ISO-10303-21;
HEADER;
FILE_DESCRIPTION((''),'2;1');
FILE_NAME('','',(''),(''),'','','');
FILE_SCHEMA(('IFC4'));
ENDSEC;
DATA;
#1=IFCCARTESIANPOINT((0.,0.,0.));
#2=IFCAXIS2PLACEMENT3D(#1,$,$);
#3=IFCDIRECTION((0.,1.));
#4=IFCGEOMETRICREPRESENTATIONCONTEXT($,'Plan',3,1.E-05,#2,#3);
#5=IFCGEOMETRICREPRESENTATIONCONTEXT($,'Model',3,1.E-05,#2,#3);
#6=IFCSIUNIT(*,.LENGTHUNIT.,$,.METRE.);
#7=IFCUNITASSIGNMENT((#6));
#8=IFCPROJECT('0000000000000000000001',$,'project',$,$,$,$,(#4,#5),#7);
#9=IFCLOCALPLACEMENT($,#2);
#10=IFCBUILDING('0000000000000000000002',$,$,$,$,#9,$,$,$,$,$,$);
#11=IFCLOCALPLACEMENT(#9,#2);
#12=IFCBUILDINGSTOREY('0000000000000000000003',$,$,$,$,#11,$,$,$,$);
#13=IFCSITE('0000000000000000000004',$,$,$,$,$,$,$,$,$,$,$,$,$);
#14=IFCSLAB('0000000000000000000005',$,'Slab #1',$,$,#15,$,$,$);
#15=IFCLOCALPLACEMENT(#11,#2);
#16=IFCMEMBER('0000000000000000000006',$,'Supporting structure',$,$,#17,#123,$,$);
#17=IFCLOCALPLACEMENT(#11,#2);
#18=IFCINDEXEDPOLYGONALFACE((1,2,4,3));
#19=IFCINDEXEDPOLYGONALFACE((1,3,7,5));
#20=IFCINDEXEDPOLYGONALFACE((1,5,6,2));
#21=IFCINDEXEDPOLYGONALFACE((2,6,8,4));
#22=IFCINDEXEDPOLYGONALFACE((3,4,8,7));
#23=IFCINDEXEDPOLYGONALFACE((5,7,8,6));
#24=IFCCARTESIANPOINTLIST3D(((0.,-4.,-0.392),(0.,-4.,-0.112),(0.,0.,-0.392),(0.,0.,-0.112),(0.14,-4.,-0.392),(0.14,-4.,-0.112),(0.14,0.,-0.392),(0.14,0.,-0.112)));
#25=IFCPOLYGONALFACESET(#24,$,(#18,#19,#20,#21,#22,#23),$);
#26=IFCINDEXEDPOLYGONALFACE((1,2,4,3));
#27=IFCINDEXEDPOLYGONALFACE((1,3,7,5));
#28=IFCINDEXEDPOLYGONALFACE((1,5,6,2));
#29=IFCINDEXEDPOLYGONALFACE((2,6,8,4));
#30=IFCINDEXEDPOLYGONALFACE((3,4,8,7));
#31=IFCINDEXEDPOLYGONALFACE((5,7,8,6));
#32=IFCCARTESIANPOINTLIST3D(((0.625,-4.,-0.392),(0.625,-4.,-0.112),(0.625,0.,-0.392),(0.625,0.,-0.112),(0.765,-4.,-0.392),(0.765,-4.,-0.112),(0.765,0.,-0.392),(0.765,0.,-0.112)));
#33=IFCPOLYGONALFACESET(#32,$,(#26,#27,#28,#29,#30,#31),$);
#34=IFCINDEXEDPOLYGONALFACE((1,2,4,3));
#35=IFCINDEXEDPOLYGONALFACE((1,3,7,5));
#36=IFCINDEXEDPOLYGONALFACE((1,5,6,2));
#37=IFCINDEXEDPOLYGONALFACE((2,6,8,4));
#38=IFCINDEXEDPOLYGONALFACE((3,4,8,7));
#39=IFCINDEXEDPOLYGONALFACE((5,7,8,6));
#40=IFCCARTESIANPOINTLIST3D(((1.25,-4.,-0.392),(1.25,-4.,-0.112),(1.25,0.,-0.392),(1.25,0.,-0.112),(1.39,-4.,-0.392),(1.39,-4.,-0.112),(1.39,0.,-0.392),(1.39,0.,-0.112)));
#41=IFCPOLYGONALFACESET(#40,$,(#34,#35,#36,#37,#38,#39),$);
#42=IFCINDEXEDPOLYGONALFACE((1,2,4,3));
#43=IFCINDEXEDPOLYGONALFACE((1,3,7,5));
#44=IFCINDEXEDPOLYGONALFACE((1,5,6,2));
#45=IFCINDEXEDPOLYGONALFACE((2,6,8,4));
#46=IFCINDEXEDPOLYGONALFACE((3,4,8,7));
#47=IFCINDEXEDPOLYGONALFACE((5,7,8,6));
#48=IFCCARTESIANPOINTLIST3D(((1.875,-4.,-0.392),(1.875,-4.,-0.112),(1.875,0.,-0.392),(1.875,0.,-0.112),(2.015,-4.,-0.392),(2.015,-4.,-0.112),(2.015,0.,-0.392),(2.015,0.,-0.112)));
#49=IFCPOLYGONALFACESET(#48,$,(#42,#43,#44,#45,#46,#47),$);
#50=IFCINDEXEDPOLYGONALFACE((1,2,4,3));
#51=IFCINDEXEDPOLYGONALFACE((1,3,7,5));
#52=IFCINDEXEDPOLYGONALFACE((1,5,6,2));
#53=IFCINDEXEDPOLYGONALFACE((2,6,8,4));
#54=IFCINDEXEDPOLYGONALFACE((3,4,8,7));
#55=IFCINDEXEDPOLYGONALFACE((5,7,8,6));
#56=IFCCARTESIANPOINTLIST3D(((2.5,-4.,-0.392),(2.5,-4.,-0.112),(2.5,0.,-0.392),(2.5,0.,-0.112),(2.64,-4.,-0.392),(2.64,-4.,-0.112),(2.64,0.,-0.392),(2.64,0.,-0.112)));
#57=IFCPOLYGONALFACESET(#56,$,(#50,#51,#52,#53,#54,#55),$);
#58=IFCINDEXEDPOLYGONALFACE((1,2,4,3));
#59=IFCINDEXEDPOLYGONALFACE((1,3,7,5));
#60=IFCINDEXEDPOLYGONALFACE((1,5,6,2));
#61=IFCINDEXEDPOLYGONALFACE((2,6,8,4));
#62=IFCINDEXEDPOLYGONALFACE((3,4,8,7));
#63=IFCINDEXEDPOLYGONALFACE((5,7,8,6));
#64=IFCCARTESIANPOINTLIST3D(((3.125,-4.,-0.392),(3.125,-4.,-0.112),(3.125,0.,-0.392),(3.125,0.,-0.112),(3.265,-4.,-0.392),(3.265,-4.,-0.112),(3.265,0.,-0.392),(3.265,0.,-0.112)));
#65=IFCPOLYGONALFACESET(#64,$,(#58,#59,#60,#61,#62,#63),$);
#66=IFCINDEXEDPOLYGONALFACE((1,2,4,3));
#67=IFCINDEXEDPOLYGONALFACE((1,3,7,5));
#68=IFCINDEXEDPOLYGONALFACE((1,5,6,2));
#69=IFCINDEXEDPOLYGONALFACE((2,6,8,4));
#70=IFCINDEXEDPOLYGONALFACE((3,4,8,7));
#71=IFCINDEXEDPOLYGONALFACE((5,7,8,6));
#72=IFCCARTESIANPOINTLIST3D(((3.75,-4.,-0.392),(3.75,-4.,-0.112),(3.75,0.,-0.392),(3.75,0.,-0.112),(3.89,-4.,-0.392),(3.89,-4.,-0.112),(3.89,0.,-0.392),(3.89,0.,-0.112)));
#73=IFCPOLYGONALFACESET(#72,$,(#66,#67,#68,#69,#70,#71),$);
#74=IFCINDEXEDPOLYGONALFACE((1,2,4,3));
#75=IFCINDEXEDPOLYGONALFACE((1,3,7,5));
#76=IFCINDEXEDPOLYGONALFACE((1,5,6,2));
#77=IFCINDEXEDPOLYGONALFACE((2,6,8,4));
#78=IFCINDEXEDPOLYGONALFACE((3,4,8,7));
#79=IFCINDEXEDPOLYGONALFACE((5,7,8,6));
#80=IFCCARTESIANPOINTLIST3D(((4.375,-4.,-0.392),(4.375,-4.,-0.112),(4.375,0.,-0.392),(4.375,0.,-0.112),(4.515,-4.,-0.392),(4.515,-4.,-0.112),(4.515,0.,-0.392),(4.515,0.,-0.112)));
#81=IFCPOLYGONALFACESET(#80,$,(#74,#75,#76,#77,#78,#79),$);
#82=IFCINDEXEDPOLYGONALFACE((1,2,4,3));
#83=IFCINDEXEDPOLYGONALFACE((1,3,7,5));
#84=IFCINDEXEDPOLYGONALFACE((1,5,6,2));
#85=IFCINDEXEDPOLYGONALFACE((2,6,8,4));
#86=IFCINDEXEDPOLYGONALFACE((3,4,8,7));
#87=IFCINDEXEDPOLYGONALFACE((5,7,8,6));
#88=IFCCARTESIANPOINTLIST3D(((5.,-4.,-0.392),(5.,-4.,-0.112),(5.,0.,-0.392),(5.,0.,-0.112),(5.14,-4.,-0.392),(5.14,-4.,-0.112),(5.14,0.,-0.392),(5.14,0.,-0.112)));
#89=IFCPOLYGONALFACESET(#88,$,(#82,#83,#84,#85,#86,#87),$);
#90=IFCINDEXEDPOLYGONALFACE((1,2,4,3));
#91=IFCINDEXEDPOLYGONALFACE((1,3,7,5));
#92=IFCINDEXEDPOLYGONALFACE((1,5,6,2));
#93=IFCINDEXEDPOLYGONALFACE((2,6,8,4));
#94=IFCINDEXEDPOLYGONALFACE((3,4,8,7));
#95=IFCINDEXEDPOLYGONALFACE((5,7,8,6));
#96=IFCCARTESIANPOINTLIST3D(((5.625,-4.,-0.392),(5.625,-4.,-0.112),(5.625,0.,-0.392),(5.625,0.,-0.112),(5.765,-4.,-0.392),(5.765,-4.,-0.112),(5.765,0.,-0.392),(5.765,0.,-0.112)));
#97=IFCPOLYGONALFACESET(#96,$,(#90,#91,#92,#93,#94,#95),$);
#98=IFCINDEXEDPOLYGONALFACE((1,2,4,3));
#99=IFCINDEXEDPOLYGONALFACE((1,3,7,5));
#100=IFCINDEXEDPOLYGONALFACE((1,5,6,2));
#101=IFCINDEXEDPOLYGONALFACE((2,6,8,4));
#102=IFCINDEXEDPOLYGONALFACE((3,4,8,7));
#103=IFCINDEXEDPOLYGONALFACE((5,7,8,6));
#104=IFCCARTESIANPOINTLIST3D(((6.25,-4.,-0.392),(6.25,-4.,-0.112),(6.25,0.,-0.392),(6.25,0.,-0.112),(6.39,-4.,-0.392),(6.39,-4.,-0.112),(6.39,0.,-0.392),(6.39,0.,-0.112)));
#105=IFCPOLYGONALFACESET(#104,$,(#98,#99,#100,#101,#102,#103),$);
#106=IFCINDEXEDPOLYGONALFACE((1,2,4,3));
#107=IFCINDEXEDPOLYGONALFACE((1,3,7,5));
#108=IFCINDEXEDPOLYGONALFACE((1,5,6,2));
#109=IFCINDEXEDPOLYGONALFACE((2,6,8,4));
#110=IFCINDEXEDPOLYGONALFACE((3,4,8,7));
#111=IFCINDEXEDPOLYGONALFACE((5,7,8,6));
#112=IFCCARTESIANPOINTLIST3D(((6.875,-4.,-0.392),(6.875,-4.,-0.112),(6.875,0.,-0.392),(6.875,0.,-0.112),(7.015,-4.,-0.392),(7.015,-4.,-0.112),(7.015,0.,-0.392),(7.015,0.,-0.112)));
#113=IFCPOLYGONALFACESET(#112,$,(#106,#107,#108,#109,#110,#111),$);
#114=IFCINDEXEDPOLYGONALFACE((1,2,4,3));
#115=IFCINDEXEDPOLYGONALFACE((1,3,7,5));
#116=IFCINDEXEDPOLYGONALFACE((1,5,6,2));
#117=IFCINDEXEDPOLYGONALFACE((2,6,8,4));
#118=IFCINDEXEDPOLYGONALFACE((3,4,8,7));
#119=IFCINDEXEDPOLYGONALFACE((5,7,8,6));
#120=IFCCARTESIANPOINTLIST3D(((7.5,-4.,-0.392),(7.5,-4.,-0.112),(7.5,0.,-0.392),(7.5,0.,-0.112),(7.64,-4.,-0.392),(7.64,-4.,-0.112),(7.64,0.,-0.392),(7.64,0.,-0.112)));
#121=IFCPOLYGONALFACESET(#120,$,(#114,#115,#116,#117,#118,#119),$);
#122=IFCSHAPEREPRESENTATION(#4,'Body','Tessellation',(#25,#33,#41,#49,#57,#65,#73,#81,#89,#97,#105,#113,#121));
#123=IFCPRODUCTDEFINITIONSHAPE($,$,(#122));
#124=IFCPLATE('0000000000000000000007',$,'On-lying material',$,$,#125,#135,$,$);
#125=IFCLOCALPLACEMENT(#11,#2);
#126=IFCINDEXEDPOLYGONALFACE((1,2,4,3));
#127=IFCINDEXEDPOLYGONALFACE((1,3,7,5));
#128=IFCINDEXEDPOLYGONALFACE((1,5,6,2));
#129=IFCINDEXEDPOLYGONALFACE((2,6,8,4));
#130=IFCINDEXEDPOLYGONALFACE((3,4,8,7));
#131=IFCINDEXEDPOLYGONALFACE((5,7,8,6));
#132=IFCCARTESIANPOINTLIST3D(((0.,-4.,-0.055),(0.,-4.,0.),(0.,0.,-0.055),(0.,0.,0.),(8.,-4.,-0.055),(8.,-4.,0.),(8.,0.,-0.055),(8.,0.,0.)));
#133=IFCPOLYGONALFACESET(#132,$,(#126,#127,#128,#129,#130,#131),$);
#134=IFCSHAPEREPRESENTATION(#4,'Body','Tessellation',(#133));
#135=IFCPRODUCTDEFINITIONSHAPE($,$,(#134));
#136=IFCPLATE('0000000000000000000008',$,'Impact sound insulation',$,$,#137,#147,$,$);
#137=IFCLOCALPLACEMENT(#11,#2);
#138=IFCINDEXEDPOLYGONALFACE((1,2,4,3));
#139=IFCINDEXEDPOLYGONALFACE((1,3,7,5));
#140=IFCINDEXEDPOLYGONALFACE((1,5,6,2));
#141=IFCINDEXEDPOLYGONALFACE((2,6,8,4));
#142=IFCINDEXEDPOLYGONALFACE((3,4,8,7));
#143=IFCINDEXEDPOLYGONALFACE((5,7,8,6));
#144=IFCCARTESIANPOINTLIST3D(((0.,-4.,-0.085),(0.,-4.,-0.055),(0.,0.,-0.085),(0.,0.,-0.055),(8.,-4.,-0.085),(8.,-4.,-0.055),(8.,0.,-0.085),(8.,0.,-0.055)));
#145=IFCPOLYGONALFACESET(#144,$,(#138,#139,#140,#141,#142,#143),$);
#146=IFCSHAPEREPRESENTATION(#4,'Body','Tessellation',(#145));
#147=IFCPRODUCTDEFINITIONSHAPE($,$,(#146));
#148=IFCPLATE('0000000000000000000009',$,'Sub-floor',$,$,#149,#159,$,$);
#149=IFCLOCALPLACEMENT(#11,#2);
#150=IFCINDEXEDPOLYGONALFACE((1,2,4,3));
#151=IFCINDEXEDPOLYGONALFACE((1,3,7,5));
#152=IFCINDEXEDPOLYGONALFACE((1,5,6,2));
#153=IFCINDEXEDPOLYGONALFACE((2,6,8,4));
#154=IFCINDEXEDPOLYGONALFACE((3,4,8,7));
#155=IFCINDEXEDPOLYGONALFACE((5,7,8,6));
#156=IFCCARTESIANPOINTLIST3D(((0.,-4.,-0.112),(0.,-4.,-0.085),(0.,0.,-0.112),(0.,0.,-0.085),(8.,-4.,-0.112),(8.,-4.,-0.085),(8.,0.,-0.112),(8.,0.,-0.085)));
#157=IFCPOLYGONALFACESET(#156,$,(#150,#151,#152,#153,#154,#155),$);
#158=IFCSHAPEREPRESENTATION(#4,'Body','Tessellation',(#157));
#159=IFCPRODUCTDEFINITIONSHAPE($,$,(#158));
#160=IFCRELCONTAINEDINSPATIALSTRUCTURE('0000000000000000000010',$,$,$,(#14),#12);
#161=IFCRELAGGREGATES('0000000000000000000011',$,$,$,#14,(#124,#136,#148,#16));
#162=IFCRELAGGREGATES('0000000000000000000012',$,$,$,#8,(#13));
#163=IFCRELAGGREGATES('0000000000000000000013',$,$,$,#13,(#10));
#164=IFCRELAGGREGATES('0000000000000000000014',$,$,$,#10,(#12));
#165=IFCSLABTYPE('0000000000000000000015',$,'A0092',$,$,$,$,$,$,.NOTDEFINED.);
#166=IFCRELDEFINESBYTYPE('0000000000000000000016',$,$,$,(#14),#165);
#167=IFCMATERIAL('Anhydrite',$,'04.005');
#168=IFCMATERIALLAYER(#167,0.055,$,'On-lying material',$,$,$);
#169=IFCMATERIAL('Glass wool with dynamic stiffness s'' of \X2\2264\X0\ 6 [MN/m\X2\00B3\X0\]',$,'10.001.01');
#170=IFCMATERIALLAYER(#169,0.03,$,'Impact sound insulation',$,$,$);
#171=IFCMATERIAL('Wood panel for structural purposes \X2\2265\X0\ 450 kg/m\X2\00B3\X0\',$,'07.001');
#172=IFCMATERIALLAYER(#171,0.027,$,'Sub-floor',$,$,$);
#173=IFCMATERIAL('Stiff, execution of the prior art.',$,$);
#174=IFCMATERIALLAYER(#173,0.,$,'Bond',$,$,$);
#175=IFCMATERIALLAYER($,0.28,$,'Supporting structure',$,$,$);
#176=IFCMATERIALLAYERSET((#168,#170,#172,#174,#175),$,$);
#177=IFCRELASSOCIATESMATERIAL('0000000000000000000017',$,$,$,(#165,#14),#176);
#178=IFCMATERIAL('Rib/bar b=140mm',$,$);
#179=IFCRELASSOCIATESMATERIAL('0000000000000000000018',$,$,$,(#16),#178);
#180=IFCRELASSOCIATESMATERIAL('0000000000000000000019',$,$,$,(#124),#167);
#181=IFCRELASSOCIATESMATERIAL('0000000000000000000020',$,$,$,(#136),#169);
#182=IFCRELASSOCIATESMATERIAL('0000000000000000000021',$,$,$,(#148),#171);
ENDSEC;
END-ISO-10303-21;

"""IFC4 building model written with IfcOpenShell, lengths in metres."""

from ifc_helpers import new_model, si_unit, direction, frame, frame_2d, origin, origin_with_axes, place, context, project, spatial, rectangle, extrude, material, layer, layer_set, type_object, element, aggregate, save


model = new_model("IFC4")

# Units and contexts
plan_context = context("Plan", 3, precision=1e-05, world=origin(), true_north=direction((0.0, 1.0)))
model_context = context("Model", 3, precision=1e-05, world=origin(), true_north=direction((0.0, 1.0)))
ifc_project = project(units=[si_unit("LENGTHUNIT", "METRE")], contexts=[plan_context, model_context])

# Site, building, storey
site = spatial("IfcSite", under=ifc_project)
building_placement = place(None, origin())
building = spatial("IfcBuilding", under=site, at=building_placement)
storey_placement = place(building_placement, origin())
storey = spatial("IfcBuildingStorey", under=building, at=storey_placement)

# Slab, member, plates
ifc_material_1 = material(Name="Anhydrite", Category="04.005")
ifc_layer_1 = layer(ifc_material_1, 0.055, Name="On-lying material")
ifc_material_2 = material(Name="Glass wool with dynamic stiffness s' of ≤ 6 [MN/m³]", Category="10.001.01")
ifc_layer_2 = layer(ifc_material_2, 0.03, Name="Impact sound insulation")
ifc_material_3 = material(Name="Wood panel for structural purposes ≥ 450 kg/m³", Category="07.001")
ifc_layer_3 = layer(ifc_material_3, 0.027, Name="Sub-floor")
ifc_material_4 = material(Name="Stiff, execution of the prior art.")
ifc_layer_4 = layer(ifc_material_4, 0.0, Name="Bond")
ifc_layer_5 = layer(None, 0.28, Name="Supporting structure")
ifc_layer_set = layer_set([ifc_layer_1, ifc_layer_2, ifc_layer_3, ifc_layer_4, ifc_layer_5])
slab_type = type_object("IfcSlabType", Name="A0092", PredefinedType="NOTDEFINED", material=ifc_layer_set)
slab_placement = place(None, frame((0.0, 0.0, 0.0), z_axis=(0.0, 0.0, -1.0), x_axis=(1.0, 0.0, 0.0)))
slab = element("IfcSlab", 1, at=slab_placement, inside=storey, type_object=slab_type, material=ifc_layer_set, Name="Slab #1")
ifc_material_5 = material(Name="Rib/bar b=140mm")
member_placement = place(slab_placement, origin())
member = element("IfcMember", 2, at=member_placement, material=ifc_material_5, Name="Supporting structure", context=plan_context, shape_type="SweptSolid", body=[
    extrude(rectangle(XDim=0.14, YDim=0.28, at=frame_2d((0.07, 0.14), x_axis=(1.0, 0.0))), frame((0.0, 4.0, 0.112), z_axis=(0.0, -1.0, 0.0), x_axis=(1.0, 0.0, 0.0)), (0.0, 0.0, 1.0), 4.0),
    extrude(rectangle(XDim=0.14, YDim=0.28, at=frame_2d((0.07, 0.14), x_axis=(1.0, 0.0))), frame((0.625, 4.0, 0.112), z_axis=(0.0, -1.0, 0.0), x_axis=(1.0, 0.0, 0.0)), (0.0, 0.0, 1.0), 4.0),
    extrude(rectangle(XDim=0.14, YDim=0.28, at=frame_2d((0.07, 0.14), x_axis=(1.0, 0.0))), frame((1.25, 4.0, 0.112), z_axis=(0.0, -1.0, 0.0), x_axis=(1.0, 0.0, 0.0)), (0.0, 0.0, 1.0), 4.0),
    extrude(rectangle(XDim=0.14, YDim=0.28, at=frame_2d((0.07, 0.14), x_axis=(1.0, 0.0))), frame((1.875, 4.0, 0.112), z_axis=(0.0, -1.0, 0.0), x_axis=(1.0, 0.0, 0.0)), (0.0, 0.0, 1.0), 4.0),
    extrude(rectangle(XDim=0.14, YDim=0.28, at=frame_2d((0.07, 0.14), x_axis=(1.0, 0.0))), frame((2.5, 4.0, 0.112), z_axis=(0.0, -1.0, 0.0), x_axis=(1.0, 0.0, 0.0)), (0.0, 0.0, 1.0), 4.0),
    extrude(rectangle(XDim=0.14, YDim=0.28, at=frame_2d((0.07, 0.14), x_axis=(1.0, 0.0))), frame((3.125, 4.0, 0.112), z_axis=(0.0, -1.0, 0.0), x_axis=(1.0, 0.0, 0.0)), (0.0, 0.0, 1.0), 4.0),
    extrude(rectangle(XDim=0.14, YDim=0.28, at=frame_2d((0.07, 0.14), x_axis=(1.0, 0.0))), frame((3.75, 4.0, 0.112), z_axis=(0.0, -1.0, 0.0), x_axis=(1.0, 0.0, 0.0)), (0.0, 0.0, 1.0), 4.0),
    extrude(rectangle(XDim=0.14, YDim=0.28, at=frame_2d((0.07, 0.14), x_axis=(1.0, 0.0))), frame((4.375, 4.0, 0.112), z_axis=(0.0, -1.0, 0.0), x_axis=(1.0, 0.0, 0.0)), (0.0, 0.0, 1.0), 4.0),
    extrude(rectangle(XDim=0.14, YDim=0.28, at=frame_2d((0.07, 0.14), x_axis=(1.0, 0.0))), frame((5.0, 4.0, 0.112), z_axis=(0.0, -1.0, 0.0), x_axis=(1.0, 0.0, 0.0)), (0.0, 0.0, 1.0), 4.0),
    extrude(rectangle(XDim=0.14, YDim=0.28, at=frame_2d((0.07, 0.14), x_axis=(1.0, 0.0))), frame((5.625, 4.0, 0.112), z_axis=(0.0, -1.0, 0.0), x_axis=(1.0, 0.0, 0.0)), (0.0, 0.0, 1.0), 4.0),
    extrude(rectangle(XDim=0.14, YDim=0.28, at=frame_2d((0.07, 0.14), x_axis=(1.0, 0.0))), frame((6.25, 4.0, 0.112), z_axis=(0.0, -1.0, 0.0), x_axis=(1.0, 0.0, 0.0)), (0.0, 0.0, 1.0), 4.0),
    extrude(rectangle(XDim=0.14, YDim=0.28, at=frame_2d((0.07, 0.14), x_axis=(1.0, 0.0))), frame((6.875, 4.0, 0.112), z_axis=(0.0, -1.0, 0.0), x_axis=(1.0, 0.0, 0.0)), (0.0, 0.0, 1.0), 4.0),
    extrude(rectangle(XDim=0.14, YDim=0.28, at=frame_2d((0.07, 0.14), x_axis=(1.0, 0.0))), frame((7.5, 4.0, 0.112), z_axis=(0.0, -1.0, 0.0), x_axis=(1.0, 0.0, 0.0)), (0.0, 0.0, 1.0), 4.0),
])
plate_1_placement = place(slab_placement, origin())
plate_1 = element("IfcPlate", 3, at=plate_1_placement, material=ifc_material_1, Name="On-lying material", context=plan_context, shape_type="SweptSolid", body=[
    extrude(rectangle(XDim=8.0, YDim=4.0, at=frame_2d((4.0, 2.0), x_axis=(1.0, 0.0))), origin_with_axes(), (0.0, 0.0, 1.0), 0.055),
])
plate_2_placement = place(slab_placement, origin())
plate_2 = element("IfcPlate", 4, at=plate_2_placement, material=ifc_material_2, Name="Impact sound insulation", context=plan_context, shape_type="SweptSolid", body=[
    extrude(rectangle(XDim=8.0, YDim=4.0, at=frame_2d((4.0, 2.0), x_axis=(1.0, 0.0))), frame((0.0, 0.0, 0.055), z_axis=(0.0, 0.0, 1.0), x_axis=(1.0, 0.0, 0.0)), (0.0, 0.0, 1.0), 0.03),
])
plate_3_placement = place(slab_placement, origin())
plate_3 = element("IfcPlate", 5, at=plate_3_placement, material=ifc_material_3, Name="Sub-floor", context=plan_context, shape_type="SweptSolid", body=[
    extrude(rectangle(XDim=8.0, YDim=4.0, at=frame_2d((4.0, 2.0), x_axis=(1.0, 0.0))), frame((0.0, 0.0, 0.085), z_axis=(0.0, 0.0, 1.0), x_axis=(1.0, 0.0, 0.0)), (0.0, 0.0, 1.0), 0.027),
])
aggregate(slab, [plate_1, plate_2, plate_3, member])

save(model, "model.ifc")
